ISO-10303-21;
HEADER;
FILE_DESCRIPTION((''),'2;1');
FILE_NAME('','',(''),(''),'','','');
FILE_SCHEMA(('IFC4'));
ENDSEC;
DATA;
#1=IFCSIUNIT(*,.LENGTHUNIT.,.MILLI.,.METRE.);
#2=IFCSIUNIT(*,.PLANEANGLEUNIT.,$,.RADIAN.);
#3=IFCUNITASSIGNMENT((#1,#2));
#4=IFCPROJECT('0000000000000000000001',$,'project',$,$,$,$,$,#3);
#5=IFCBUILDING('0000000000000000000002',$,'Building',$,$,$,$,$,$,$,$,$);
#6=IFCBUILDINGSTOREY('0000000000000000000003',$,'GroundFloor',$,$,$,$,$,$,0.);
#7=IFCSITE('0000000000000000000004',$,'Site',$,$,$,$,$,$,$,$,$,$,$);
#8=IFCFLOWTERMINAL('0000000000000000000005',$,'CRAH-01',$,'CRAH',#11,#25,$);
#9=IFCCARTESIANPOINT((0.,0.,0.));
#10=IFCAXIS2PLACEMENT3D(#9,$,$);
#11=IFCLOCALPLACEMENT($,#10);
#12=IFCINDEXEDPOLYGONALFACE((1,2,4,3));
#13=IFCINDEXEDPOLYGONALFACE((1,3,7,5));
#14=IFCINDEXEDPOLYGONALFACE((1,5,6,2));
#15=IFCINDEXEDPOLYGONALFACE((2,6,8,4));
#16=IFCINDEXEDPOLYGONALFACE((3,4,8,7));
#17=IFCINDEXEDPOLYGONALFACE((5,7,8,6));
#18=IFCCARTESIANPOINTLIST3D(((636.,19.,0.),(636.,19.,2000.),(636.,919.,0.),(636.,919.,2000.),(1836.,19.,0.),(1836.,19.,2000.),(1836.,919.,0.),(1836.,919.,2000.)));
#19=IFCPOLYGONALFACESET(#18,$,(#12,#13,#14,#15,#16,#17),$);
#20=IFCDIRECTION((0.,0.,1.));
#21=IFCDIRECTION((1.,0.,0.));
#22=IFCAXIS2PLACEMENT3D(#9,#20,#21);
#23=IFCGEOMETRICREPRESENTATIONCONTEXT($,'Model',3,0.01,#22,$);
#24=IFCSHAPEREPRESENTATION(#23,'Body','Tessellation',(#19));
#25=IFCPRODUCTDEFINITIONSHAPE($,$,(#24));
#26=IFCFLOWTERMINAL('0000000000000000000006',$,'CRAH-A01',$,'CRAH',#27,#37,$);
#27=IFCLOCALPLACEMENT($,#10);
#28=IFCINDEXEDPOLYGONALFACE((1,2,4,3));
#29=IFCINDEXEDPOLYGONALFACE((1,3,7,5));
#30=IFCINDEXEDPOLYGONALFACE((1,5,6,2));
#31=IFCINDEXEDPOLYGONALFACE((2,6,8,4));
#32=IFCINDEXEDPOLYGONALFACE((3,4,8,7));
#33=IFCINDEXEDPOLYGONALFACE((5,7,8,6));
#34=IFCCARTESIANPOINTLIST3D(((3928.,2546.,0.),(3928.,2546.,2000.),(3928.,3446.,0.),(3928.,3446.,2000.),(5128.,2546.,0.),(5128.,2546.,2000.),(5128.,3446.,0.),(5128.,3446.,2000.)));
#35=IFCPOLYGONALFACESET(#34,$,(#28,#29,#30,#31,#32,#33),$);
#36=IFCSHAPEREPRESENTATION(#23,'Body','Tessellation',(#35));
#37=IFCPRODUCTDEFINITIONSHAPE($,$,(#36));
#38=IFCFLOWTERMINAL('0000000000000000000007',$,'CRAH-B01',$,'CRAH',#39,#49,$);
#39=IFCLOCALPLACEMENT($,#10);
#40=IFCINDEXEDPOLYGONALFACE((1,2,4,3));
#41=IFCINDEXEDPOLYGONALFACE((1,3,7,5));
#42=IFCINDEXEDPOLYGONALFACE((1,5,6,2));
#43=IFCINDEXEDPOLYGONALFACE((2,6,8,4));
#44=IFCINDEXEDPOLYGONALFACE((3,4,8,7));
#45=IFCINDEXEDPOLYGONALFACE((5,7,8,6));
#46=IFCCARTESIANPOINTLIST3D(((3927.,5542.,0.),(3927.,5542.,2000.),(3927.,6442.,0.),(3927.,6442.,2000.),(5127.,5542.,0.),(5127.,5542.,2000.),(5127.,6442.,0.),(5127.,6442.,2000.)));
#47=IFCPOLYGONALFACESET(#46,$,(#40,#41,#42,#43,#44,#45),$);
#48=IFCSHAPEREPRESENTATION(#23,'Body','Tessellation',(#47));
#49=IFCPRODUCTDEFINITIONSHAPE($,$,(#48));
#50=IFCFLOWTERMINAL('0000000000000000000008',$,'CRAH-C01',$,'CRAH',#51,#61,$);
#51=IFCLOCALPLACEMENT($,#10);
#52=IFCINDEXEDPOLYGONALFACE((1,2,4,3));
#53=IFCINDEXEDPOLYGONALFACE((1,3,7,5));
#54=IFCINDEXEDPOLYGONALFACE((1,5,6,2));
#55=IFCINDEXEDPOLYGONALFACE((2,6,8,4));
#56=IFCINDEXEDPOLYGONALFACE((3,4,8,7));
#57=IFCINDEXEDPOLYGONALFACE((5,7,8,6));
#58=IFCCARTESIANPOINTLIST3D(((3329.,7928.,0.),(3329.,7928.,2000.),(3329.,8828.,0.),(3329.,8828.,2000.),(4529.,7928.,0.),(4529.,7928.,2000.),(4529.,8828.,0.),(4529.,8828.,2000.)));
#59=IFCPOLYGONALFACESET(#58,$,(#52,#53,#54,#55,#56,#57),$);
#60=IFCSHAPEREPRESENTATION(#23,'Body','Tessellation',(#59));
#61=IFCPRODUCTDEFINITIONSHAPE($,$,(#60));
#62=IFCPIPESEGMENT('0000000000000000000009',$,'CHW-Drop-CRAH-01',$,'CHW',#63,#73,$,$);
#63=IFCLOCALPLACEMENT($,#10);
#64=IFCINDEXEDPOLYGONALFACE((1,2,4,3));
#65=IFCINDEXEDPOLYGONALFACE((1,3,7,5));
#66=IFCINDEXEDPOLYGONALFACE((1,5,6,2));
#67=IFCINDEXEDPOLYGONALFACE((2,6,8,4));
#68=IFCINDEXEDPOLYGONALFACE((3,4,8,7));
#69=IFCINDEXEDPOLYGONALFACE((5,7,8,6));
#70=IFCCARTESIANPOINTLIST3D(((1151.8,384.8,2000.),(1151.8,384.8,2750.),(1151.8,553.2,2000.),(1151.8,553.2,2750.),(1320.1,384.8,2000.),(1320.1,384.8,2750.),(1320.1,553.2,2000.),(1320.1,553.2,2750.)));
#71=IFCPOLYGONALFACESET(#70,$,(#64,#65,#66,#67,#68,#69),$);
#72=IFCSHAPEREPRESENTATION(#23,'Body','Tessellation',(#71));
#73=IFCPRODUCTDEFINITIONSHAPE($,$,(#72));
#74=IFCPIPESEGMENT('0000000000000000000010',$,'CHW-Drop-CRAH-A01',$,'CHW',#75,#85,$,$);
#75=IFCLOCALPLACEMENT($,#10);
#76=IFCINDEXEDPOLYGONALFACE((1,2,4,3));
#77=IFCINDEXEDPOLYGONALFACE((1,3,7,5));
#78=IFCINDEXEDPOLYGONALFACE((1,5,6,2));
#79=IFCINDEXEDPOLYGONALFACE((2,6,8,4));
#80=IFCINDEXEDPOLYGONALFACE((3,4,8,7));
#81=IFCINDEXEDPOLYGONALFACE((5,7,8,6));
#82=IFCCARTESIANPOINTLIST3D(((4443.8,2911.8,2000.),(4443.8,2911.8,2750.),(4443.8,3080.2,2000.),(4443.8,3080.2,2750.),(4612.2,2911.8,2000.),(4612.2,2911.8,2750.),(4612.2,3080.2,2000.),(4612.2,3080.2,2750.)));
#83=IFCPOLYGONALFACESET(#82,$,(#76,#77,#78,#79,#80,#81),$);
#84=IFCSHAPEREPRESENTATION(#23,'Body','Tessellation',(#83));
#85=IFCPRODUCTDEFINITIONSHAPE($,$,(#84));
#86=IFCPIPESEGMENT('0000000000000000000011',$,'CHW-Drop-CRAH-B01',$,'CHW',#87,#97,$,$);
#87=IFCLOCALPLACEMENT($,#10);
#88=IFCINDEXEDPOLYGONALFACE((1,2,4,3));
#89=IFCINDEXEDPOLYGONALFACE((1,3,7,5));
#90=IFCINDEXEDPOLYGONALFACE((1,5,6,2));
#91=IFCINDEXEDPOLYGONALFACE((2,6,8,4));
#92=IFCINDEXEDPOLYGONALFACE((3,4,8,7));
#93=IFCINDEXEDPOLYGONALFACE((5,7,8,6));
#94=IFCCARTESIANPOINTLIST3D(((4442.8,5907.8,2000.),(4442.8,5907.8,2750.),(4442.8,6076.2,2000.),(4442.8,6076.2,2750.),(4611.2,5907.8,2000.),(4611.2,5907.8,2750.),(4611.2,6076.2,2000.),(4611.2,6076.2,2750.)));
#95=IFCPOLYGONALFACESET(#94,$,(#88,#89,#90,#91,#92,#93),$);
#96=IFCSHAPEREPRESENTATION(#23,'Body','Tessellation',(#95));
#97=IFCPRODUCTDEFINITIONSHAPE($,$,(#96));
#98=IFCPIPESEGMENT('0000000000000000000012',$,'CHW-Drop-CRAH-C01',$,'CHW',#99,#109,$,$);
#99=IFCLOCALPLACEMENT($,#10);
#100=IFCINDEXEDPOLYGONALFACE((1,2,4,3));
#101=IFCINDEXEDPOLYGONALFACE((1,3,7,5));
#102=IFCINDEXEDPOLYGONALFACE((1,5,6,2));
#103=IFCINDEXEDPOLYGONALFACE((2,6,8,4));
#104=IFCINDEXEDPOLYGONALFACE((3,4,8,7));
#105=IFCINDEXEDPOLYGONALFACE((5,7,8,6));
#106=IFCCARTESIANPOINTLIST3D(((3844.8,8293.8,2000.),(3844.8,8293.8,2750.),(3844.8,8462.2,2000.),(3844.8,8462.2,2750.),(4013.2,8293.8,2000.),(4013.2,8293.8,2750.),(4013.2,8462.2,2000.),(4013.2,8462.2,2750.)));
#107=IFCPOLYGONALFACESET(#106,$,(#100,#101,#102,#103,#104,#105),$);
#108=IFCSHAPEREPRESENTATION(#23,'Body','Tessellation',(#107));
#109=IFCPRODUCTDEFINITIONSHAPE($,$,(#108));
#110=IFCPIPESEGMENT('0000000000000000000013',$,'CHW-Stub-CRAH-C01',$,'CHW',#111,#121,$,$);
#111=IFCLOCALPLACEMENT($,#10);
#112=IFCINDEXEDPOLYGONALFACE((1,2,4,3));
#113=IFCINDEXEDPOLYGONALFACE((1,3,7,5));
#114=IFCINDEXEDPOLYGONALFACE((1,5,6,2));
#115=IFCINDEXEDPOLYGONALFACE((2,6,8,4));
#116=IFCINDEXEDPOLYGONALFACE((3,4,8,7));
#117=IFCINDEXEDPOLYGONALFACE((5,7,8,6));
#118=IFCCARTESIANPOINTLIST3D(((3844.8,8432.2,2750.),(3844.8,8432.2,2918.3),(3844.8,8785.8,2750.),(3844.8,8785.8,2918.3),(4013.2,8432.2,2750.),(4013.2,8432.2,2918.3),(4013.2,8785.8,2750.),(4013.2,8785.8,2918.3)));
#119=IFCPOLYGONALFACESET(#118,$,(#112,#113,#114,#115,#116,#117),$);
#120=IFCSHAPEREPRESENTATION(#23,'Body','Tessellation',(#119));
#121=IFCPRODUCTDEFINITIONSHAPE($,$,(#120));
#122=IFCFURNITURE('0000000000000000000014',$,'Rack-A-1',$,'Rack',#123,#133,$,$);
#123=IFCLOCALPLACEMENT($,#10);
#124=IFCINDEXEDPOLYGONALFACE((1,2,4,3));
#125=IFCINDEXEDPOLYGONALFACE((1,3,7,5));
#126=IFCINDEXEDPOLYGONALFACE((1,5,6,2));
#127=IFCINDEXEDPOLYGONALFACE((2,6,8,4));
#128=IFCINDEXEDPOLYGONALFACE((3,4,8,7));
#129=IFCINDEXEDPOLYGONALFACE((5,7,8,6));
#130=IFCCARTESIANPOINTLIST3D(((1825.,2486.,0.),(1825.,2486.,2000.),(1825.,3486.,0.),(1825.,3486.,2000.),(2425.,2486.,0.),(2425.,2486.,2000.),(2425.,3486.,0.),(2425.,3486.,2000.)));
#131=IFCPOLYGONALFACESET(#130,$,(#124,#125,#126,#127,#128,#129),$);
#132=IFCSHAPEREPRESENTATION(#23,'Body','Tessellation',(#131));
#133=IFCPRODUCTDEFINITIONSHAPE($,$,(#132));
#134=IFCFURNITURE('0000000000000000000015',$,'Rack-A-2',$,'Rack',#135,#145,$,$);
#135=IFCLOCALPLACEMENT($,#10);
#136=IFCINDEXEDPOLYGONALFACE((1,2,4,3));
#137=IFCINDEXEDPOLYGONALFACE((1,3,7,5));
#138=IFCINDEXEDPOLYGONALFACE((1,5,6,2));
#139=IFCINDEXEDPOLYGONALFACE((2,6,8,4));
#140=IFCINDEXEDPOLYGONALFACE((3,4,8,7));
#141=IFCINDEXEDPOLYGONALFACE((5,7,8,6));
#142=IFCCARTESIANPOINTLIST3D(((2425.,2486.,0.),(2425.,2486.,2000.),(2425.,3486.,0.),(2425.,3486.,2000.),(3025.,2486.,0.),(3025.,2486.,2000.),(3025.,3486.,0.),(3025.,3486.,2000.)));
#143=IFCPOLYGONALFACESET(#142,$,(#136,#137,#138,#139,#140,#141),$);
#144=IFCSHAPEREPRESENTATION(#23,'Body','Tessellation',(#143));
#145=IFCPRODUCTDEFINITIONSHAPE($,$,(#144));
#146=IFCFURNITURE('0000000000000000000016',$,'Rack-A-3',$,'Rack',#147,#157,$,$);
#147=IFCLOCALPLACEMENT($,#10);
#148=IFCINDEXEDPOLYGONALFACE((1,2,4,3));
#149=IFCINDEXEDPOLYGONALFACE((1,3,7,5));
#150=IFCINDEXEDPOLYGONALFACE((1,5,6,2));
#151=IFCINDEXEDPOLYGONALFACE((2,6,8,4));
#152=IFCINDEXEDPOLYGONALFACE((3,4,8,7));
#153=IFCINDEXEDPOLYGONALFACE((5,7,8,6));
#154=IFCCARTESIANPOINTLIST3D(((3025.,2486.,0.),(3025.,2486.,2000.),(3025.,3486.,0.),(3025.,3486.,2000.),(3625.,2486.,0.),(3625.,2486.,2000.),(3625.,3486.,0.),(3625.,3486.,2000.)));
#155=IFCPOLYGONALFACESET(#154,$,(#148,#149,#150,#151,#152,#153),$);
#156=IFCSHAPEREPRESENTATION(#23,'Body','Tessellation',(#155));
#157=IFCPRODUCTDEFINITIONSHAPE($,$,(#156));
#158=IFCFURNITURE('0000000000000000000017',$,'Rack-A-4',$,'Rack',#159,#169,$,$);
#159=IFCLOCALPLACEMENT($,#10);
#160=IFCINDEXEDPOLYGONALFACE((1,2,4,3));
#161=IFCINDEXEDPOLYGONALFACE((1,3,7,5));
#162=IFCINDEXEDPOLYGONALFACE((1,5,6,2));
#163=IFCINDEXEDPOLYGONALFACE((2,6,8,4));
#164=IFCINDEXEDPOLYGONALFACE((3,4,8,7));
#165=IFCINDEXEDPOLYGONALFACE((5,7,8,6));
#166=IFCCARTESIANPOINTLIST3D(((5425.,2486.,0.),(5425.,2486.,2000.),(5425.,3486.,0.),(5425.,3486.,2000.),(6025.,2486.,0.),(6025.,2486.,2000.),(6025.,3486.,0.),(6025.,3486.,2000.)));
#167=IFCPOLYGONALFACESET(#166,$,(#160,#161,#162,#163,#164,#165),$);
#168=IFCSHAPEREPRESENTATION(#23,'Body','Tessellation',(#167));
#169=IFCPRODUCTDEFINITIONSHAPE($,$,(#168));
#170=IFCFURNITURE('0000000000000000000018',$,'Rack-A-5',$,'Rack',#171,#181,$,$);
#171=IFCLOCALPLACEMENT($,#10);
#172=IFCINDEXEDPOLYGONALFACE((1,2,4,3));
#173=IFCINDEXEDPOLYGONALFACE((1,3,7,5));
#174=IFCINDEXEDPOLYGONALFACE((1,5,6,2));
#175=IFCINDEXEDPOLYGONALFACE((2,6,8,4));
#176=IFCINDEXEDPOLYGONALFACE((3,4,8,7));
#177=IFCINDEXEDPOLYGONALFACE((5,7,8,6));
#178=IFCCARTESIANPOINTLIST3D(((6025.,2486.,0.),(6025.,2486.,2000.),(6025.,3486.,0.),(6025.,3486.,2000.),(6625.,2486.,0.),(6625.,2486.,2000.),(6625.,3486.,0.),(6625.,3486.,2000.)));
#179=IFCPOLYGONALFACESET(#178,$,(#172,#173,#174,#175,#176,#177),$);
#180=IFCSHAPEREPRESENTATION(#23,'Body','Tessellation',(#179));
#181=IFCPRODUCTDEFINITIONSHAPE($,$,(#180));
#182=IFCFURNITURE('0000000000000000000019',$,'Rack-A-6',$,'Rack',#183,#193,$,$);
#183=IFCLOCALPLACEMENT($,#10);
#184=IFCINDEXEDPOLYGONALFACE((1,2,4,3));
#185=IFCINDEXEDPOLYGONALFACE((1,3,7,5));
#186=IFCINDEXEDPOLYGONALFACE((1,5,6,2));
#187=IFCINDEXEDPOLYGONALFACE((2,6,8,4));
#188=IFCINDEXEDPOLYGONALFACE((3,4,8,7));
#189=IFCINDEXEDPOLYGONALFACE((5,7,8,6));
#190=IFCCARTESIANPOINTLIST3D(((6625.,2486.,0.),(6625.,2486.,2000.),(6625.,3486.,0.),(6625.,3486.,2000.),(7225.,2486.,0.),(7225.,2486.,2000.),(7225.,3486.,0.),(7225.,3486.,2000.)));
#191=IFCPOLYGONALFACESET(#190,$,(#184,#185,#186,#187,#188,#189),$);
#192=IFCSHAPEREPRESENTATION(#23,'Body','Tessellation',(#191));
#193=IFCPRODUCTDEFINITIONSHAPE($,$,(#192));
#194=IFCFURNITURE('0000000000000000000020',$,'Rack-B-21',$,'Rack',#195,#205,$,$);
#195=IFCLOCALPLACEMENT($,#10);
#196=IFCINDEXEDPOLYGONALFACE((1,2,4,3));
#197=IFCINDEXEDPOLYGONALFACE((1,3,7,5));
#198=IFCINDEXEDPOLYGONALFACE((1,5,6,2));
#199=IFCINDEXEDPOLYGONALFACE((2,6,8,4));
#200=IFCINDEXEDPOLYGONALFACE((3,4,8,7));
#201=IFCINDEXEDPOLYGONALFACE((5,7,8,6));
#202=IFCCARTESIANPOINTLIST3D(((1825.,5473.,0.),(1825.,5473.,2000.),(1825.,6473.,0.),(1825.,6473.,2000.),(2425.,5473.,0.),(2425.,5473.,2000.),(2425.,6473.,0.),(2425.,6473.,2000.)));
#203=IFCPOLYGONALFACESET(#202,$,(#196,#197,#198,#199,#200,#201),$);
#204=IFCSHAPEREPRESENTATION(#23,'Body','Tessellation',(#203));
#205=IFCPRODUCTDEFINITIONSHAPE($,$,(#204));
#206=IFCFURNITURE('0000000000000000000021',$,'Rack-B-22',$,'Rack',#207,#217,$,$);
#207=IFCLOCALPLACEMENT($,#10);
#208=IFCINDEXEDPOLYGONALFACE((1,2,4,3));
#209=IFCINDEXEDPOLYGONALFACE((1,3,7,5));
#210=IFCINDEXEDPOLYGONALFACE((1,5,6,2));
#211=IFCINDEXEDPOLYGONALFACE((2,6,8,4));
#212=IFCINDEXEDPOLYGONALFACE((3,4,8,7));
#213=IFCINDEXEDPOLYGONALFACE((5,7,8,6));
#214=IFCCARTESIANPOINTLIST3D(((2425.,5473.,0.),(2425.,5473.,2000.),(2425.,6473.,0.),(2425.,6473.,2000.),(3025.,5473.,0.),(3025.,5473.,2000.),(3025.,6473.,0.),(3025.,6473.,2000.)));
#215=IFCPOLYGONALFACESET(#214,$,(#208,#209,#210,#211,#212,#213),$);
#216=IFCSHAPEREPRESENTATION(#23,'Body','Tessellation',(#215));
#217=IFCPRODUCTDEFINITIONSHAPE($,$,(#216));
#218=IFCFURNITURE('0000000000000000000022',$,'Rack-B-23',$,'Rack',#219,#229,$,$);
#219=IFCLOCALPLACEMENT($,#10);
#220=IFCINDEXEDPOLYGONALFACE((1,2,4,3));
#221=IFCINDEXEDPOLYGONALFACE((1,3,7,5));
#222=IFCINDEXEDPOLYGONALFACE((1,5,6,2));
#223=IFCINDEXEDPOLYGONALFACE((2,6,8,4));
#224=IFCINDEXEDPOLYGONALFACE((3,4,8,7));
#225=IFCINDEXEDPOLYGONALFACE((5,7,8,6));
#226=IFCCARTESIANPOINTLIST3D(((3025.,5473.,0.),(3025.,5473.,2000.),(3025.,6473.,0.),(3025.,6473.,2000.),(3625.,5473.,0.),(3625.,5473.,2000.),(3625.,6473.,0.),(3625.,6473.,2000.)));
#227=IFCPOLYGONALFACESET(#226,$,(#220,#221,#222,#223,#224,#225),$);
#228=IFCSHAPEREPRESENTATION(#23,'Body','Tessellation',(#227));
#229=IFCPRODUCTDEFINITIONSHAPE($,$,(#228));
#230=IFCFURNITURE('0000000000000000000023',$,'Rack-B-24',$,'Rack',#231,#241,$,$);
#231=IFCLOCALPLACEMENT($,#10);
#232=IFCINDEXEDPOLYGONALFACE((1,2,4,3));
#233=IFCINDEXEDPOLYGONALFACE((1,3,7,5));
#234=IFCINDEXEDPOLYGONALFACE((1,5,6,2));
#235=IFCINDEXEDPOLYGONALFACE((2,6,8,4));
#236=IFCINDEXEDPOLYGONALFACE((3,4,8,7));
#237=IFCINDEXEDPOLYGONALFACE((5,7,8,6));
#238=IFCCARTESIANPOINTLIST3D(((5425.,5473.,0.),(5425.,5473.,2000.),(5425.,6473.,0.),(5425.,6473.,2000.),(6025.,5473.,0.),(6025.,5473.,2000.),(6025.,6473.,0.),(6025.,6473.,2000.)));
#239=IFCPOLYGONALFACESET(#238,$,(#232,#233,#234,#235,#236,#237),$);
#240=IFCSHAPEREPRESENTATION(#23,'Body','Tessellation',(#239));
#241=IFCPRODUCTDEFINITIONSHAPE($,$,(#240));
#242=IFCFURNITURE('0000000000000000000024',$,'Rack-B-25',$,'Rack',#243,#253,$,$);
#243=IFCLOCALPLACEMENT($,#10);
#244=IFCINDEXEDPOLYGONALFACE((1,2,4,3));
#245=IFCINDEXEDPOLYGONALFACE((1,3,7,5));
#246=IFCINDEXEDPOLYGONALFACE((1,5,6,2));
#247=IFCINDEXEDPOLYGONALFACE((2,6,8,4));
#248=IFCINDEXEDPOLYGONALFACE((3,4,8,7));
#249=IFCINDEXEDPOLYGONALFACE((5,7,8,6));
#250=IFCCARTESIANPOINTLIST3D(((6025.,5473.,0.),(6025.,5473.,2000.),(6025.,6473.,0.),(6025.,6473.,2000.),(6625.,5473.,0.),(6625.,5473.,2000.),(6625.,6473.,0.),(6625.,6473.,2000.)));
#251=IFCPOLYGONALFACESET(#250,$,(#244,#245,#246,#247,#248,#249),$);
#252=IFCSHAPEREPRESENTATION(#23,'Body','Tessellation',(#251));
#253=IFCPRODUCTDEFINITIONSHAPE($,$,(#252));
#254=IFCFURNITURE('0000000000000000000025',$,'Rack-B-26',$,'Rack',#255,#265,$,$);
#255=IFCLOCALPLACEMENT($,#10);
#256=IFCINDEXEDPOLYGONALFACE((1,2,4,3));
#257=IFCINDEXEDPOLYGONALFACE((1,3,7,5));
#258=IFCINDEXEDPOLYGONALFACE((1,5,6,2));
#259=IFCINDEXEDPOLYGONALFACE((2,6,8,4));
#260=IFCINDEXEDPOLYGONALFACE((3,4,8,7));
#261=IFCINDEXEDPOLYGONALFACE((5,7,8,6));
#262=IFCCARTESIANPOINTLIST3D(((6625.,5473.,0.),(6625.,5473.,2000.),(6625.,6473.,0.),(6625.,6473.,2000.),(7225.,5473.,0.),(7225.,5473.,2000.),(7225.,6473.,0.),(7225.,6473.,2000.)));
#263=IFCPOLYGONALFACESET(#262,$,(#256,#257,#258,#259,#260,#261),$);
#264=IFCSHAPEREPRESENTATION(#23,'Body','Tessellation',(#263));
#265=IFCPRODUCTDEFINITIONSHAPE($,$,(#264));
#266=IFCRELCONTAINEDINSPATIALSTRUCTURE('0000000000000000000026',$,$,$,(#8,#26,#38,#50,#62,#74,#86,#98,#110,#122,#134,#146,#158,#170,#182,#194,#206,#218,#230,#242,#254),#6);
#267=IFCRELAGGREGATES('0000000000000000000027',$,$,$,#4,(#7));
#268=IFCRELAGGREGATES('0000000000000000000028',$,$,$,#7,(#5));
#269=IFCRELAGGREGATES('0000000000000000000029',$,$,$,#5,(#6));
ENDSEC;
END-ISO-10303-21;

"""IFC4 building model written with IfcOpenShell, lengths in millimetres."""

from ifc_helpers import new_model, si_unit, frame, origin, origin_with_axes, origin_2d, place, context, project, spatial, rectangle, extrude, element, save


model = new_model("IFC4")

# Units and contexts
model_context = context("Model", 3, precision=0.01, world=origin_with_axes())
ifc_project = project(units=[si_unit("LENGTHUNIT", "METRE", prefix="MILLI"), si_unit("PLANEANGLEUNIT", "RADIAN")])

# Site, building, storey
site = spatial("IfcSite", under=ifc_project, Name="Site")
building = spatial("IfcBuilding", under=site, Name="Building")
storey = spatial("IfcBuildingStorey", under=building, Name="GroundFloor", Elevation=0.0)

# Flow terminals
for number, where, z_axis, x_axis, name in (
    (1, (1236.0, 469.0, 0.0), (0.0, 0.0, 1.0), (1.0, 0.0, 0.0), "CRAH-01"),
    (2, (4528.0, 2996.0, 0.0), (0.0, 0.0, 1.0), (1.0, 0.0, 0.0), "CRAH-A01"),
    (3, (4527.0, 5992.0, 0.0), (0.0, 0.0, 1.0), (1.0, 0.0, 0.0), "CRAH-B01"),
    (4, (3929.0, 8378.0, 0.0), (0.0, 0.0, 1.0), (1.0, 0.0, 0.0), "CRAH-C01"),
):
    element("IfcFlowTerminal", number, at=place(None, frame(where, z_axis=z_axis, x_axis=x_axis)), inside=storey, Name=name, ObjectType="CRAH", context=model_context, shape_type="SweptSolid", body=[
        extrude(rectangle(XDim=1200.0, YDim=900.0, at=origin_2d()), origin(), (0.0, 0.0, 1.0), 2000.0),
    ])

# Pipe segments
for number, where, z_axis, x_axis, name in (
    (5, (1236.0, 469.0, 2000.0), (0.0, 0.0, 1.0), (1.0, 0.0, 0.0), "CHW-Drop-CRAH-01"),
    (6, (4528.0, 2996.0, 2000.0), (0.0, 0.0, 1.0), (1.0, 0.0, 0.0), "CHW-Drop-CRAH-A01"),
    (7, (4527.0, 5992.0, 2000.0), (0.0, 0.0, 1.0), (1.0, 0.0, 0.0), "CHW-Drop-CRAH-B01"),
    (8, (3929.0, 8378.0, 2000.0), (0.0, 0.0, 1.0), (1.0, 0.0, 0.0), "CHW-Drop-CRAH-C01"),
):
    element("IfcPipeSegment", number, at=place(None, frame(where, z_axis=z_axis, x_axis=x_axis)), inside=storey, Name=name, ObjectType="CHW", context=model_context, shape_type="SweptSolid", body=[
        extrude(rectangle(XDim=168.3, YDim=168.3, at=origin_2d()), origin(), (0.0, 0.0, 1.0), 750.0),
    ])
pipe_segment_placement = place(None, frame((3929.0, 8609.0, 2750.0), z_axis=(0.0, 0.0, 1.0), x_axis=(1.0, 0.0, 0.0)))
element("IfcPipeSegment", 9, at=pipe_segment_placement, inside=storey, Name="CHW-Stub-CRAH-C01", ObjectType="CHW", context=model_context, shape_type="SweptSolid", body=[
    extrude(rectangle(XDim=168.3, YDim=353.7, at=origin_2d()), origin(), (0.0, 0.0, 1.0), 168.3),
])

# Furniture
for number, where, z_axis, x_axis, name in (
    (10, (2125.0, 2986.0, 0.0), (0.0, 0.0, 1.0), (1.0, 0.0, 0.0), "Rack-A-1"),
    (11, (2725.0, 2986.0, 0.0), (0.0, 0.0, 1.0), (1.0, 0.0, 0.0), "Rack-A-2"),
    (12, (3325.0, 2986.0, 0.0), (0.0, 0.0, 1.0), (1.0, 0.0, 0.0), "Rack-A-3"),
    (13, (5725.0, 2986.0, 0.0), (0.0, 0.0, 1.0), (1.0, 0.0, 0.0), "Rack-A-4"),
    (14, (6325.0, 2986.0, 0.0), (0.0, 0.0, 1.0), (1.0, 0.0, 0.0), "Rack-A-5"),
    (15, (6925.0, 2986.0, 0.0), (0.0, 0.0, 1.0), (1.0, 0.0, 0.0), "Rack-A-6"),
    (16, (2125.0, 5973.0, 0.0), (0.0, 0.0, 1.0), (1.0, 0.0, 0.0), "Rack-B-21"),
    (17, (2725.0, 5973.0, 0.0), (0.0, 0.0, 1.0), (1.0, 0.0, 0.0), "Rack-B-22"),
    (18, (3325.0, 5973.0, 0.0), (0.0, 0.0, 1.0), (1.0, 0.0, 0.0), "Rack-B-23"),
    (19, (5725.0, 5973.0, 0.0), (0.0, 0.0, 1.0), (1.0, 0.0, 0.0), "Rack-B-24"),
    (20, (6325.0, 5973.0, 0.0), (0.0, 0.0, 1.0), (1.0, 0.0, 0.0), "Rack-B-25"),
    (21, (6925.0, 5973.0, 0.0), (0.0, 0.0, 1.0), (1.0, 0.0, 0.0), "Rack-B-26"),
):
    element("IfcFurniture", number, at=place(None, frame(where, z_axis=z_axis, x_axis=x_axis)), inside=storey, Name=name, ObjectType="Rack", context=model_context, shape_type="SweptSolid", body=[
        extrude(rectangle(XDim=600.0, YDim=1000.0, at=origin_2d()), origin(), (0.0, 0.0, 1.0), 2000.0),
    ])

save(model, "model.ifc")
